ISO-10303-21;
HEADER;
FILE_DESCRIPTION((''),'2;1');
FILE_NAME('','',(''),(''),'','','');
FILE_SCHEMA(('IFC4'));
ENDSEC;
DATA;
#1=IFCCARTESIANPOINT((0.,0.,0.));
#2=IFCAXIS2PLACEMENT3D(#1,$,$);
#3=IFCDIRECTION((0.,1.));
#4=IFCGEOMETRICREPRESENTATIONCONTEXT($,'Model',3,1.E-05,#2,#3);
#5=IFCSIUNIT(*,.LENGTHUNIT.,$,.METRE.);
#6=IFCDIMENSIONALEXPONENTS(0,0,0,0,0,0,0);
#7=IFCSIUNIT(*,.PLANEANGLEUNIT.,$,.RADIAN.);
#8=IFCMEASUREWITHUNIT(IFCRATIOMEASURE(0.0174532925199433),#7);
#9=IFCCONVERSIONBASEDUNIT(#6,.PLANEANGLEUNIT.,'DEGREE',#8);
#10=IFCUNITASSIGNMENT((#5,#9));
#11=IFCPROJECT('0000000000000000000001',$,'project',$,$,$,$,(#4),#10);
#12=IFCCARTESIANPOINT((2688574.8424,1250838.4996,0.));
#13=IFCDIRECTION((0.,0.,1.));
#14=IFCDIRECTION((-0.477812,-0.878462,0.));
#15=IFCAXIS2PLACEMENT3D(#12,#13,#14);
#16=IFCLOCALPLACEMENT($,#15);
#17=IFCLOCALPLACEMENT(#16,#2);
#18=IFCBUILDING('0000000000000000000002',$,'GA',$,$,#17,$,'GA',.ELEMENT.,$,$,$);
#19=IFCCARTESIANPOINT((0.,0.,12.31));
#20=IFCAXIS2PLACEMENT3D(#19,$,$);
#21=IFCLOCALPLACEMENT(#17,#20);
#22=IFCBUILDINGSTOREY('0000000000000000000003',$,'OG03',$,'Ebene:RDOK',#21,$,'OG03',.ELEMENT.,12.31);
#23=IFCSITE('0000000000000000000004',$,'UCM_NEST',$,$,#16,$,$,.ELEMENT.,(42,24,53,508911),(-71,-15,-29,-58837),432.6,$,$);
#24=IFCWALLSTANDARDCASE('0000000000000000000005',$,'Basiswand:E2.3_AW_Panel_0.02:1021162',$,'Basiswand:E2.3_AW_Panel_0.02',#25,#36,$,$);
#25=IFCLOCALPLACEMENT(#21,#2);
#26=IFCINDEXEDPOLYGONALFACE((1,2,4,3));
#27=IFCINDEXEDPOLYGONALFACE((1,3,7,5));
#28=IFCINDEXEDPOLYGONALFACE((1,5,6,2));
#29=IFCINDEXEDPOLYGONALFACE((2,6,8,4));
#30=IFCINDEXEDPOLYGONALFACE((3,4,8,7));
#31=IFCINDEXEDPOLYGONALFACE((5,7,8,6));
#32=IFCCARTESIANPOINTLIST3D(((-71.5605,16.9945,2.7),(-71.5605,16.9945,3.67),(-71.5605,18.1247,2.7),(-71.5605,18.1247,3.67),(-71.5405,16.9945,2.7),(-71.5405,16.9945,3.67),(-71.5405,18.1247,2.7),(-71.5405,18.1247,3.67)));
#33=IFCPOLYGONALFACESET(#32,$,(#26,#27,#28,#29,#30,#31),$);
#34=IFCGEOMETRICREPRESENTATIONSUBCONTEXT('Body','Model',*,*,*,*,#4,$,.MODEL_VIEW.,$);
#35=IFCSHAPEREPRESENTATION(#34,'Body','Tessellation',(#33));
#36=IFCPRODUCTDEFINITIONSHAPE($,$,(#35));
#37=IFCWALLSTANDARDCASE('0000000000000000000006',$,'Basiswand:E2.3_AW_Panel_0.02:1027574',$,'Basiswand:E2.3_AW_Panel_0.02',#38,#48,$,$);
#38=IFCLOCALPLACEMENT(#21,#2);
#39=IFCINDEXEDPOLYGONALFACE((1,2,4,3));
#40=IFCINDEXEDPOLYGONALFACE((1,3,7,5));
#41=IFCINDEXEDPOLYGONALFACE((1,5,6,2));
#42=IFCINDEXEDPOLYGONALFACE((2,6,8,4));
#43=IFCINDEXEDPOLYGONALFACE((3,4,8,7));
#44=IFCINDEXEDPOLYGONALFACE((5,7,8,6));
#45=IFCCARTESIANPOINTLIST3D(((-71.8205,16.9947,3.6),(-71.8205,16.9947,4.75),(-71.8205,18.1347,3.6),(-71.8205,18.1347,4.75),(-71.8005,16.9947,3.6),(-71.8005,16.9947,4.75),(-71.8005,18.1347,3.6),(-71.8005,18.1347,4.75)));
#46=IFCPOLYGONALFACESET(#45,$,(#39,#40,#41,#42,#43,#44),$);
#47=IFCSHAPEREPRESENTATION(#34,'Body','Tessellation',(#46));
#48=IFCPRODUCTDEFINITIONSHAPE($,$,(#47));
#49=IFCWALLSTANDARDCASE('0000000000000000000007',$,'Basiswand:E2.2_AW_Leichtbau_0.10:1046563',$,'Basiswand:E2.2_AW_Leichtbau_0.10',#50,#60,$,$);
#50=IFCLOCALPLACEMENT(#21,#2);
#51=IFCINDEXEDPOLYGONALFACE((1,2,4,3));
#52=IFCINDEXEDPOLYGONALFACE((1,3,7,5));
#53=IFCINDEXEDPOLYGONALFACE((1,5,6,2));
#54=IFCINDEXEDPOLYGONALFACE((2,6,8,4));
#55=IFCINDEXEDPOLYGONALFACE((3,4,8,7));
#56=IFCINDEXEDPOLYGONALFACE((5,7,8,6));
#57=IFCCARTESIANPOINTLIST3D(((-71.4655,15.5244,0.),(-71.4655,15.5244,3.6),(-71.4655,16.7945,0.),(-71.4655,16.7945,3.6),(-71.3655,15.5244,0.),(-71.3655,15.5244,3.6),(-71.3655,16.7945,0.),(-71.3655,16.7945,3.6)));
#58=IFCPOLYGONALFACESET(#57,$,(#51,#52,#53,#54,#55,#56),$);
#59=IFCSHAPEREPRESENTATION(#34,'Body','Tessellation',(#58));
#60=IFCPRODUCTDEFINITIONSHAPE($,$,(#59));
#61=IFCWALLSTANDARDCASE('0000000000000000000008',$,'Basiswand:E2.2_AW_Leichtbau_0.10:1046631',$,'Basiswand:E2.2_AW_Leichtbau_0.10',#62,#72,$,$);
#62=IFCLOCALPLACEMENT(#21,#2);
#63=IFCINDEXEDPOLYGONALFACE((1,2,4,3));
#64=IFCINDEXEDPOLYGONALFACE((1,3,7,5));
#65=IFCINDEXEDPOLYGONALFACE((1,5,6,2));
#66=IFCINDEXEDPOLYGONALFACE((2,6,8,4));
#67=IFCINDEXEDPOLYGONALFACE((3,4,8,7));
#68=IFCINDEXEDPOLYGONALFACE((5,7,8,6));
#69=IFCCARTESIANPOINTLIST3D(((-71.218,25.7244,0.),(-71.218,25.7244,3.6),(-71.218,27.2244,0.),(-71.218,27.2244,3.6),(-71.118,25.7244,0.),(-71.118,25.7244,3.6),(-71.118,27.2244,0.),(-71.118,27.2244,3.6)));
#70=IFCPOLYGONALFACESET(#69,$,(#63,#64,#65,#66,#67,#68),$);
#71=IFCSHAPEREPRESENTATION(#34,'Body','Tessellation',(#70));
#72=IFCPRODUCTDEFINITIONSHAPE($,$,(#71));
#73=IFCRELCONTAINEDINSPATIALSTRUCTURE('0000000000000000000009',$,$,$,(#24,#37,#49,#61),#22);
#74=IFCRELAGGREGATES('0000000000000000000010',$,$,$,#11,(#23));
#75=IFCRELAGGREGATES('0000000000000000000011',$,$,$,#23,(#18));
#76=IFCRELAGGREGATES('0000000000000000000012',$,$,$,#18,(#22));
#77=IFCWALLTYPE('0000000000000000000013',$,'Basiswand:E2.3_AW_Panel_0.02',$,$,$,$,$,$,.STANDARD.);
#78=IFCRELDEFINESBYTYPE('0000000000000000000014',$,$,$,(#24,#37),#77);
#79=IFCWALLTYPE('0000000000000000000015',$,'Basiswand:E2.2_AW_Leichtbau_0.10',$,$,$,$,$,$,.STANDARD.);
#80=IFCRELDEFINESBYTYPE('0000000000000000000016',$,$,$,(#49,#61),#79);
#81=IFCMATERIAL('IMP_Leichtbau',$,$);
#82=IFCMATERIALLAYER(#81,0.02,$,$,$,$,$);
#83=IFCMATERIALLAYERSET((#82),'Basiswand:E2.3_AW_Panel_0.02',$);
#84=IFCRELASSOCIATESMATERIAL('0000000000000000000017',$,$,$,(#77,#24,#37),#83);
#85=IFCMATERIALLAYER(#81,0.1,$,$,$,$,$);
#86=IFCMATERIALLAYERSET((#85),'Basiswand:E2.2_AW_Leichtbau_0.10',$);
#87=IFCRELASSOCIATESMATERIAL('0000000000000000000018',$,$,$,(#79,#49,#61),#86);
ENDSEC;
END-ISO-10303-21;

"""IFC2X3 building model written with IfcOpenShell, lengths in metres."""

from ifc_helpers import new_model, entity, si_unit, converted_unit, direction, frame, frame_2d, origin, place, context, subcontext, project, spatial, rectangle, extrude, material, layer, layer_set, layer_usage, type_object, element, save


model = new_model("IFC2X3")

# Units and contexts
model_context = context("Model", 3, precision=1e-05, world=origin(), true_north=direction((0.0, 1.0)))
body_context = subcontext(model_context, "Body", "Model", "MODEL_VIEW")
ifc_project = project(units=[si_unit("LENGTHUNIT", "METRE"), converted_unit("PLANEANGLEUNIT", "DEGREE", entity("IfcRatioMeasure", 0.0174532925199433), si_unit("PLANEANGLEUNIT", "RADIAN"), dimensions=[0, 0, 0, 0, 0, 0, 0])], contexts=[model_context])

# Site, building, storey
site_placement = place(None, frame((2688574.8424, 1250838.4996, 0.0), z_axis=(0.0, 0.0, 1.0), x_axis=(-0.477812, -0.878462, 0.0)))
site = spatial("IfcSite", under=ifc_project, at=site_placement, Name="UCM_NEST", CompositionType="ELEMENT", RefLatitude=(42, 24, 53, 508911), RefLongitude=(-71, -15, -29, -58837), RefElevation=432.6)
building_placement = place(site_placement, origin())
building = spatial("IfcBuilding", under=site, at=building_placement, Name="GA", LongName="GA", CompositionType="ELEMENT")
storey_placement = place(building_placement, frame((0.0, 0.0, 12.31)))
storey = spatial("IfcBuildingStorey", under=building, at=storey_placement, Name="OG03", ObjectType="Ebene:RDOK", LongName="OG03", CompositionType="ELEMENT", Elevation=12.31)

# Shared definitions
ifc_material_1 = material(Name="IMP_Leichtbau")

# Walls
ifc_layer_1 = layer(ifc_material_1, 0.02)
ifc_layer_set_1 = layer_set([ifc_layer_1], Name="Basiswand:E2.3_AW_Panel_0.02")
wall_type_1 = type_object("IfcWallType", Name="Basiswand:E2.3_AW_Panel_0.02", PredefinedType="STANDARD", material=ifc_layer_set_1)
ifc_layer_usage_1 = layer_usage(ifc_layer_set_1, "AXIS2", "NEGATIVE", 0.01)
wall_1_placement = place(storey_placement, frame((-71.5505, 16.9945, 2.7), z_axis=(0.0, 0.0, 1.0), x_axis=(0.0, 1.0, 0.0)))
element("IfcWallStandardCase", 1, at=wall_1_placement, inside=storey, type_object=wall_type_1, material=ifc_layer_usage_1, Name="Basiswand:E2.3_AW_Panel_0.02:1021162", ObjectType="Basiswand:E2.3_AW_Panel_0.02", context=body_context, shape_type="SweptSolid", body=[
    extrude(rectangle(XDim=1.1302, YDim=0.02, at=frame_2d((0.5651, 0.0), x_axis=(-1.0, 0.0))), origin(), (0.0, 0.0, 1.0), 0.97),
])
ifc_layer_usage_2 = layer_usage(ifc_layer_set_1, "AXIS2", "NEGATIVE", 0.01)
wall_2_placement = place(storey_placement, frame((-71.8105, 18.1347, 3.6), z_axis=(0.0, 0.0, 1.0), x_axis=(0.0, -1.0, 0.0)))
element("IfcWallStandardCase", 2, at=wall_2_placement, inside=storey, type_object=wall_type_1, material=ifc_layer_usage_2, Name="Basiswand:E2.3_AW_Panel_0.02:1027574", ObjectType="Basiswand:E2.3_AW_Panel_0.02", context=body_context, shape_type="SweptSolid", body=[
    extrude(rectangle(XDim=1.14, YDim=0.02, at=frame_2d((0.57, 0.0), x_axis=(-1.0, 0.0))), origin(), (0.0, 0.0, 1.0), 1.15),
])

# Walls
ifc_layer_2 = layer(ifc_material_1, 0.1)
ifc_layer_set_2 = layer_set([ifc_layer_2], Name="Basiswand:E2.2_AW_Leichtbau_0.10")
ifc_layer_usage_3 = layer_usage(ifc_layer_set_2, "AXIS2", "NEGATIVE", 0.05)
wall_type_2 = type_object("IfcWallType", Name="Basiswand:E2.2_AW_Leichtbau_0.10", PredefinedType="STANDARD", material=ifc_layer_set_2)
wall_3_placement = place(storey_placement, frame((-71.4155, 16.7945, 0.0), z_axis=(0.0, 0.0, 1.0), x_axis=(0.0, -1.0, 0.0)))
element("IfcWallStandardCase", 3, at=wall_3_placement, inside=storey, type_object=wall_type_2, material=ifc_layer_usage_3, Name="Basiswand:E2.2_AW_Leichtbau_0.10:1046563", ObjectType="Basiswand:E2.2_AW_Leichtbau_0.10", context=body_context, shape_type="SweptSolid", body=[
    extrude(rectangle(XDim=1.27, YDim=0.1, at=frame_2d((0.635, 0.0), x_axis=(-1.0, 0.0))), origin(), (0.0, 0.0, 1.0), 3.6),
])
ifc_layer_usage_4 = layer_usage(ifc_layer_set_2, "AXIS2", "NEGATIVE", 0.05)
wall_4_placement = place(storey_placement, frame((-71.168, 27.2244, 0.0), z_axis=(0.0, 0.0, 1.0), x_axis=(0.0, -1.0, 0.0)))
element("IfcWallStandardCase", 4, at=wall_4_placement, inside=storey, type_object=wall_type_2, material=ifc_layer_usage_4, Name="Basiswand:E2.2_AW_Leichtbau_0.10:1046631", ObjectType="Basiswand:E2.2_AW_Leichtbau_0.10", context=body_context, shape_type="SweptSolid", body=[
    extrude(rectangle(XDim=1.5, YDim=0.1, at=frame_2d((0.75, 0.0), x_axis=(-1.0, 0.0))), origin(), (0.0, 0.0, 1.0), 3.6),
])

save(model, "model.ifc")
